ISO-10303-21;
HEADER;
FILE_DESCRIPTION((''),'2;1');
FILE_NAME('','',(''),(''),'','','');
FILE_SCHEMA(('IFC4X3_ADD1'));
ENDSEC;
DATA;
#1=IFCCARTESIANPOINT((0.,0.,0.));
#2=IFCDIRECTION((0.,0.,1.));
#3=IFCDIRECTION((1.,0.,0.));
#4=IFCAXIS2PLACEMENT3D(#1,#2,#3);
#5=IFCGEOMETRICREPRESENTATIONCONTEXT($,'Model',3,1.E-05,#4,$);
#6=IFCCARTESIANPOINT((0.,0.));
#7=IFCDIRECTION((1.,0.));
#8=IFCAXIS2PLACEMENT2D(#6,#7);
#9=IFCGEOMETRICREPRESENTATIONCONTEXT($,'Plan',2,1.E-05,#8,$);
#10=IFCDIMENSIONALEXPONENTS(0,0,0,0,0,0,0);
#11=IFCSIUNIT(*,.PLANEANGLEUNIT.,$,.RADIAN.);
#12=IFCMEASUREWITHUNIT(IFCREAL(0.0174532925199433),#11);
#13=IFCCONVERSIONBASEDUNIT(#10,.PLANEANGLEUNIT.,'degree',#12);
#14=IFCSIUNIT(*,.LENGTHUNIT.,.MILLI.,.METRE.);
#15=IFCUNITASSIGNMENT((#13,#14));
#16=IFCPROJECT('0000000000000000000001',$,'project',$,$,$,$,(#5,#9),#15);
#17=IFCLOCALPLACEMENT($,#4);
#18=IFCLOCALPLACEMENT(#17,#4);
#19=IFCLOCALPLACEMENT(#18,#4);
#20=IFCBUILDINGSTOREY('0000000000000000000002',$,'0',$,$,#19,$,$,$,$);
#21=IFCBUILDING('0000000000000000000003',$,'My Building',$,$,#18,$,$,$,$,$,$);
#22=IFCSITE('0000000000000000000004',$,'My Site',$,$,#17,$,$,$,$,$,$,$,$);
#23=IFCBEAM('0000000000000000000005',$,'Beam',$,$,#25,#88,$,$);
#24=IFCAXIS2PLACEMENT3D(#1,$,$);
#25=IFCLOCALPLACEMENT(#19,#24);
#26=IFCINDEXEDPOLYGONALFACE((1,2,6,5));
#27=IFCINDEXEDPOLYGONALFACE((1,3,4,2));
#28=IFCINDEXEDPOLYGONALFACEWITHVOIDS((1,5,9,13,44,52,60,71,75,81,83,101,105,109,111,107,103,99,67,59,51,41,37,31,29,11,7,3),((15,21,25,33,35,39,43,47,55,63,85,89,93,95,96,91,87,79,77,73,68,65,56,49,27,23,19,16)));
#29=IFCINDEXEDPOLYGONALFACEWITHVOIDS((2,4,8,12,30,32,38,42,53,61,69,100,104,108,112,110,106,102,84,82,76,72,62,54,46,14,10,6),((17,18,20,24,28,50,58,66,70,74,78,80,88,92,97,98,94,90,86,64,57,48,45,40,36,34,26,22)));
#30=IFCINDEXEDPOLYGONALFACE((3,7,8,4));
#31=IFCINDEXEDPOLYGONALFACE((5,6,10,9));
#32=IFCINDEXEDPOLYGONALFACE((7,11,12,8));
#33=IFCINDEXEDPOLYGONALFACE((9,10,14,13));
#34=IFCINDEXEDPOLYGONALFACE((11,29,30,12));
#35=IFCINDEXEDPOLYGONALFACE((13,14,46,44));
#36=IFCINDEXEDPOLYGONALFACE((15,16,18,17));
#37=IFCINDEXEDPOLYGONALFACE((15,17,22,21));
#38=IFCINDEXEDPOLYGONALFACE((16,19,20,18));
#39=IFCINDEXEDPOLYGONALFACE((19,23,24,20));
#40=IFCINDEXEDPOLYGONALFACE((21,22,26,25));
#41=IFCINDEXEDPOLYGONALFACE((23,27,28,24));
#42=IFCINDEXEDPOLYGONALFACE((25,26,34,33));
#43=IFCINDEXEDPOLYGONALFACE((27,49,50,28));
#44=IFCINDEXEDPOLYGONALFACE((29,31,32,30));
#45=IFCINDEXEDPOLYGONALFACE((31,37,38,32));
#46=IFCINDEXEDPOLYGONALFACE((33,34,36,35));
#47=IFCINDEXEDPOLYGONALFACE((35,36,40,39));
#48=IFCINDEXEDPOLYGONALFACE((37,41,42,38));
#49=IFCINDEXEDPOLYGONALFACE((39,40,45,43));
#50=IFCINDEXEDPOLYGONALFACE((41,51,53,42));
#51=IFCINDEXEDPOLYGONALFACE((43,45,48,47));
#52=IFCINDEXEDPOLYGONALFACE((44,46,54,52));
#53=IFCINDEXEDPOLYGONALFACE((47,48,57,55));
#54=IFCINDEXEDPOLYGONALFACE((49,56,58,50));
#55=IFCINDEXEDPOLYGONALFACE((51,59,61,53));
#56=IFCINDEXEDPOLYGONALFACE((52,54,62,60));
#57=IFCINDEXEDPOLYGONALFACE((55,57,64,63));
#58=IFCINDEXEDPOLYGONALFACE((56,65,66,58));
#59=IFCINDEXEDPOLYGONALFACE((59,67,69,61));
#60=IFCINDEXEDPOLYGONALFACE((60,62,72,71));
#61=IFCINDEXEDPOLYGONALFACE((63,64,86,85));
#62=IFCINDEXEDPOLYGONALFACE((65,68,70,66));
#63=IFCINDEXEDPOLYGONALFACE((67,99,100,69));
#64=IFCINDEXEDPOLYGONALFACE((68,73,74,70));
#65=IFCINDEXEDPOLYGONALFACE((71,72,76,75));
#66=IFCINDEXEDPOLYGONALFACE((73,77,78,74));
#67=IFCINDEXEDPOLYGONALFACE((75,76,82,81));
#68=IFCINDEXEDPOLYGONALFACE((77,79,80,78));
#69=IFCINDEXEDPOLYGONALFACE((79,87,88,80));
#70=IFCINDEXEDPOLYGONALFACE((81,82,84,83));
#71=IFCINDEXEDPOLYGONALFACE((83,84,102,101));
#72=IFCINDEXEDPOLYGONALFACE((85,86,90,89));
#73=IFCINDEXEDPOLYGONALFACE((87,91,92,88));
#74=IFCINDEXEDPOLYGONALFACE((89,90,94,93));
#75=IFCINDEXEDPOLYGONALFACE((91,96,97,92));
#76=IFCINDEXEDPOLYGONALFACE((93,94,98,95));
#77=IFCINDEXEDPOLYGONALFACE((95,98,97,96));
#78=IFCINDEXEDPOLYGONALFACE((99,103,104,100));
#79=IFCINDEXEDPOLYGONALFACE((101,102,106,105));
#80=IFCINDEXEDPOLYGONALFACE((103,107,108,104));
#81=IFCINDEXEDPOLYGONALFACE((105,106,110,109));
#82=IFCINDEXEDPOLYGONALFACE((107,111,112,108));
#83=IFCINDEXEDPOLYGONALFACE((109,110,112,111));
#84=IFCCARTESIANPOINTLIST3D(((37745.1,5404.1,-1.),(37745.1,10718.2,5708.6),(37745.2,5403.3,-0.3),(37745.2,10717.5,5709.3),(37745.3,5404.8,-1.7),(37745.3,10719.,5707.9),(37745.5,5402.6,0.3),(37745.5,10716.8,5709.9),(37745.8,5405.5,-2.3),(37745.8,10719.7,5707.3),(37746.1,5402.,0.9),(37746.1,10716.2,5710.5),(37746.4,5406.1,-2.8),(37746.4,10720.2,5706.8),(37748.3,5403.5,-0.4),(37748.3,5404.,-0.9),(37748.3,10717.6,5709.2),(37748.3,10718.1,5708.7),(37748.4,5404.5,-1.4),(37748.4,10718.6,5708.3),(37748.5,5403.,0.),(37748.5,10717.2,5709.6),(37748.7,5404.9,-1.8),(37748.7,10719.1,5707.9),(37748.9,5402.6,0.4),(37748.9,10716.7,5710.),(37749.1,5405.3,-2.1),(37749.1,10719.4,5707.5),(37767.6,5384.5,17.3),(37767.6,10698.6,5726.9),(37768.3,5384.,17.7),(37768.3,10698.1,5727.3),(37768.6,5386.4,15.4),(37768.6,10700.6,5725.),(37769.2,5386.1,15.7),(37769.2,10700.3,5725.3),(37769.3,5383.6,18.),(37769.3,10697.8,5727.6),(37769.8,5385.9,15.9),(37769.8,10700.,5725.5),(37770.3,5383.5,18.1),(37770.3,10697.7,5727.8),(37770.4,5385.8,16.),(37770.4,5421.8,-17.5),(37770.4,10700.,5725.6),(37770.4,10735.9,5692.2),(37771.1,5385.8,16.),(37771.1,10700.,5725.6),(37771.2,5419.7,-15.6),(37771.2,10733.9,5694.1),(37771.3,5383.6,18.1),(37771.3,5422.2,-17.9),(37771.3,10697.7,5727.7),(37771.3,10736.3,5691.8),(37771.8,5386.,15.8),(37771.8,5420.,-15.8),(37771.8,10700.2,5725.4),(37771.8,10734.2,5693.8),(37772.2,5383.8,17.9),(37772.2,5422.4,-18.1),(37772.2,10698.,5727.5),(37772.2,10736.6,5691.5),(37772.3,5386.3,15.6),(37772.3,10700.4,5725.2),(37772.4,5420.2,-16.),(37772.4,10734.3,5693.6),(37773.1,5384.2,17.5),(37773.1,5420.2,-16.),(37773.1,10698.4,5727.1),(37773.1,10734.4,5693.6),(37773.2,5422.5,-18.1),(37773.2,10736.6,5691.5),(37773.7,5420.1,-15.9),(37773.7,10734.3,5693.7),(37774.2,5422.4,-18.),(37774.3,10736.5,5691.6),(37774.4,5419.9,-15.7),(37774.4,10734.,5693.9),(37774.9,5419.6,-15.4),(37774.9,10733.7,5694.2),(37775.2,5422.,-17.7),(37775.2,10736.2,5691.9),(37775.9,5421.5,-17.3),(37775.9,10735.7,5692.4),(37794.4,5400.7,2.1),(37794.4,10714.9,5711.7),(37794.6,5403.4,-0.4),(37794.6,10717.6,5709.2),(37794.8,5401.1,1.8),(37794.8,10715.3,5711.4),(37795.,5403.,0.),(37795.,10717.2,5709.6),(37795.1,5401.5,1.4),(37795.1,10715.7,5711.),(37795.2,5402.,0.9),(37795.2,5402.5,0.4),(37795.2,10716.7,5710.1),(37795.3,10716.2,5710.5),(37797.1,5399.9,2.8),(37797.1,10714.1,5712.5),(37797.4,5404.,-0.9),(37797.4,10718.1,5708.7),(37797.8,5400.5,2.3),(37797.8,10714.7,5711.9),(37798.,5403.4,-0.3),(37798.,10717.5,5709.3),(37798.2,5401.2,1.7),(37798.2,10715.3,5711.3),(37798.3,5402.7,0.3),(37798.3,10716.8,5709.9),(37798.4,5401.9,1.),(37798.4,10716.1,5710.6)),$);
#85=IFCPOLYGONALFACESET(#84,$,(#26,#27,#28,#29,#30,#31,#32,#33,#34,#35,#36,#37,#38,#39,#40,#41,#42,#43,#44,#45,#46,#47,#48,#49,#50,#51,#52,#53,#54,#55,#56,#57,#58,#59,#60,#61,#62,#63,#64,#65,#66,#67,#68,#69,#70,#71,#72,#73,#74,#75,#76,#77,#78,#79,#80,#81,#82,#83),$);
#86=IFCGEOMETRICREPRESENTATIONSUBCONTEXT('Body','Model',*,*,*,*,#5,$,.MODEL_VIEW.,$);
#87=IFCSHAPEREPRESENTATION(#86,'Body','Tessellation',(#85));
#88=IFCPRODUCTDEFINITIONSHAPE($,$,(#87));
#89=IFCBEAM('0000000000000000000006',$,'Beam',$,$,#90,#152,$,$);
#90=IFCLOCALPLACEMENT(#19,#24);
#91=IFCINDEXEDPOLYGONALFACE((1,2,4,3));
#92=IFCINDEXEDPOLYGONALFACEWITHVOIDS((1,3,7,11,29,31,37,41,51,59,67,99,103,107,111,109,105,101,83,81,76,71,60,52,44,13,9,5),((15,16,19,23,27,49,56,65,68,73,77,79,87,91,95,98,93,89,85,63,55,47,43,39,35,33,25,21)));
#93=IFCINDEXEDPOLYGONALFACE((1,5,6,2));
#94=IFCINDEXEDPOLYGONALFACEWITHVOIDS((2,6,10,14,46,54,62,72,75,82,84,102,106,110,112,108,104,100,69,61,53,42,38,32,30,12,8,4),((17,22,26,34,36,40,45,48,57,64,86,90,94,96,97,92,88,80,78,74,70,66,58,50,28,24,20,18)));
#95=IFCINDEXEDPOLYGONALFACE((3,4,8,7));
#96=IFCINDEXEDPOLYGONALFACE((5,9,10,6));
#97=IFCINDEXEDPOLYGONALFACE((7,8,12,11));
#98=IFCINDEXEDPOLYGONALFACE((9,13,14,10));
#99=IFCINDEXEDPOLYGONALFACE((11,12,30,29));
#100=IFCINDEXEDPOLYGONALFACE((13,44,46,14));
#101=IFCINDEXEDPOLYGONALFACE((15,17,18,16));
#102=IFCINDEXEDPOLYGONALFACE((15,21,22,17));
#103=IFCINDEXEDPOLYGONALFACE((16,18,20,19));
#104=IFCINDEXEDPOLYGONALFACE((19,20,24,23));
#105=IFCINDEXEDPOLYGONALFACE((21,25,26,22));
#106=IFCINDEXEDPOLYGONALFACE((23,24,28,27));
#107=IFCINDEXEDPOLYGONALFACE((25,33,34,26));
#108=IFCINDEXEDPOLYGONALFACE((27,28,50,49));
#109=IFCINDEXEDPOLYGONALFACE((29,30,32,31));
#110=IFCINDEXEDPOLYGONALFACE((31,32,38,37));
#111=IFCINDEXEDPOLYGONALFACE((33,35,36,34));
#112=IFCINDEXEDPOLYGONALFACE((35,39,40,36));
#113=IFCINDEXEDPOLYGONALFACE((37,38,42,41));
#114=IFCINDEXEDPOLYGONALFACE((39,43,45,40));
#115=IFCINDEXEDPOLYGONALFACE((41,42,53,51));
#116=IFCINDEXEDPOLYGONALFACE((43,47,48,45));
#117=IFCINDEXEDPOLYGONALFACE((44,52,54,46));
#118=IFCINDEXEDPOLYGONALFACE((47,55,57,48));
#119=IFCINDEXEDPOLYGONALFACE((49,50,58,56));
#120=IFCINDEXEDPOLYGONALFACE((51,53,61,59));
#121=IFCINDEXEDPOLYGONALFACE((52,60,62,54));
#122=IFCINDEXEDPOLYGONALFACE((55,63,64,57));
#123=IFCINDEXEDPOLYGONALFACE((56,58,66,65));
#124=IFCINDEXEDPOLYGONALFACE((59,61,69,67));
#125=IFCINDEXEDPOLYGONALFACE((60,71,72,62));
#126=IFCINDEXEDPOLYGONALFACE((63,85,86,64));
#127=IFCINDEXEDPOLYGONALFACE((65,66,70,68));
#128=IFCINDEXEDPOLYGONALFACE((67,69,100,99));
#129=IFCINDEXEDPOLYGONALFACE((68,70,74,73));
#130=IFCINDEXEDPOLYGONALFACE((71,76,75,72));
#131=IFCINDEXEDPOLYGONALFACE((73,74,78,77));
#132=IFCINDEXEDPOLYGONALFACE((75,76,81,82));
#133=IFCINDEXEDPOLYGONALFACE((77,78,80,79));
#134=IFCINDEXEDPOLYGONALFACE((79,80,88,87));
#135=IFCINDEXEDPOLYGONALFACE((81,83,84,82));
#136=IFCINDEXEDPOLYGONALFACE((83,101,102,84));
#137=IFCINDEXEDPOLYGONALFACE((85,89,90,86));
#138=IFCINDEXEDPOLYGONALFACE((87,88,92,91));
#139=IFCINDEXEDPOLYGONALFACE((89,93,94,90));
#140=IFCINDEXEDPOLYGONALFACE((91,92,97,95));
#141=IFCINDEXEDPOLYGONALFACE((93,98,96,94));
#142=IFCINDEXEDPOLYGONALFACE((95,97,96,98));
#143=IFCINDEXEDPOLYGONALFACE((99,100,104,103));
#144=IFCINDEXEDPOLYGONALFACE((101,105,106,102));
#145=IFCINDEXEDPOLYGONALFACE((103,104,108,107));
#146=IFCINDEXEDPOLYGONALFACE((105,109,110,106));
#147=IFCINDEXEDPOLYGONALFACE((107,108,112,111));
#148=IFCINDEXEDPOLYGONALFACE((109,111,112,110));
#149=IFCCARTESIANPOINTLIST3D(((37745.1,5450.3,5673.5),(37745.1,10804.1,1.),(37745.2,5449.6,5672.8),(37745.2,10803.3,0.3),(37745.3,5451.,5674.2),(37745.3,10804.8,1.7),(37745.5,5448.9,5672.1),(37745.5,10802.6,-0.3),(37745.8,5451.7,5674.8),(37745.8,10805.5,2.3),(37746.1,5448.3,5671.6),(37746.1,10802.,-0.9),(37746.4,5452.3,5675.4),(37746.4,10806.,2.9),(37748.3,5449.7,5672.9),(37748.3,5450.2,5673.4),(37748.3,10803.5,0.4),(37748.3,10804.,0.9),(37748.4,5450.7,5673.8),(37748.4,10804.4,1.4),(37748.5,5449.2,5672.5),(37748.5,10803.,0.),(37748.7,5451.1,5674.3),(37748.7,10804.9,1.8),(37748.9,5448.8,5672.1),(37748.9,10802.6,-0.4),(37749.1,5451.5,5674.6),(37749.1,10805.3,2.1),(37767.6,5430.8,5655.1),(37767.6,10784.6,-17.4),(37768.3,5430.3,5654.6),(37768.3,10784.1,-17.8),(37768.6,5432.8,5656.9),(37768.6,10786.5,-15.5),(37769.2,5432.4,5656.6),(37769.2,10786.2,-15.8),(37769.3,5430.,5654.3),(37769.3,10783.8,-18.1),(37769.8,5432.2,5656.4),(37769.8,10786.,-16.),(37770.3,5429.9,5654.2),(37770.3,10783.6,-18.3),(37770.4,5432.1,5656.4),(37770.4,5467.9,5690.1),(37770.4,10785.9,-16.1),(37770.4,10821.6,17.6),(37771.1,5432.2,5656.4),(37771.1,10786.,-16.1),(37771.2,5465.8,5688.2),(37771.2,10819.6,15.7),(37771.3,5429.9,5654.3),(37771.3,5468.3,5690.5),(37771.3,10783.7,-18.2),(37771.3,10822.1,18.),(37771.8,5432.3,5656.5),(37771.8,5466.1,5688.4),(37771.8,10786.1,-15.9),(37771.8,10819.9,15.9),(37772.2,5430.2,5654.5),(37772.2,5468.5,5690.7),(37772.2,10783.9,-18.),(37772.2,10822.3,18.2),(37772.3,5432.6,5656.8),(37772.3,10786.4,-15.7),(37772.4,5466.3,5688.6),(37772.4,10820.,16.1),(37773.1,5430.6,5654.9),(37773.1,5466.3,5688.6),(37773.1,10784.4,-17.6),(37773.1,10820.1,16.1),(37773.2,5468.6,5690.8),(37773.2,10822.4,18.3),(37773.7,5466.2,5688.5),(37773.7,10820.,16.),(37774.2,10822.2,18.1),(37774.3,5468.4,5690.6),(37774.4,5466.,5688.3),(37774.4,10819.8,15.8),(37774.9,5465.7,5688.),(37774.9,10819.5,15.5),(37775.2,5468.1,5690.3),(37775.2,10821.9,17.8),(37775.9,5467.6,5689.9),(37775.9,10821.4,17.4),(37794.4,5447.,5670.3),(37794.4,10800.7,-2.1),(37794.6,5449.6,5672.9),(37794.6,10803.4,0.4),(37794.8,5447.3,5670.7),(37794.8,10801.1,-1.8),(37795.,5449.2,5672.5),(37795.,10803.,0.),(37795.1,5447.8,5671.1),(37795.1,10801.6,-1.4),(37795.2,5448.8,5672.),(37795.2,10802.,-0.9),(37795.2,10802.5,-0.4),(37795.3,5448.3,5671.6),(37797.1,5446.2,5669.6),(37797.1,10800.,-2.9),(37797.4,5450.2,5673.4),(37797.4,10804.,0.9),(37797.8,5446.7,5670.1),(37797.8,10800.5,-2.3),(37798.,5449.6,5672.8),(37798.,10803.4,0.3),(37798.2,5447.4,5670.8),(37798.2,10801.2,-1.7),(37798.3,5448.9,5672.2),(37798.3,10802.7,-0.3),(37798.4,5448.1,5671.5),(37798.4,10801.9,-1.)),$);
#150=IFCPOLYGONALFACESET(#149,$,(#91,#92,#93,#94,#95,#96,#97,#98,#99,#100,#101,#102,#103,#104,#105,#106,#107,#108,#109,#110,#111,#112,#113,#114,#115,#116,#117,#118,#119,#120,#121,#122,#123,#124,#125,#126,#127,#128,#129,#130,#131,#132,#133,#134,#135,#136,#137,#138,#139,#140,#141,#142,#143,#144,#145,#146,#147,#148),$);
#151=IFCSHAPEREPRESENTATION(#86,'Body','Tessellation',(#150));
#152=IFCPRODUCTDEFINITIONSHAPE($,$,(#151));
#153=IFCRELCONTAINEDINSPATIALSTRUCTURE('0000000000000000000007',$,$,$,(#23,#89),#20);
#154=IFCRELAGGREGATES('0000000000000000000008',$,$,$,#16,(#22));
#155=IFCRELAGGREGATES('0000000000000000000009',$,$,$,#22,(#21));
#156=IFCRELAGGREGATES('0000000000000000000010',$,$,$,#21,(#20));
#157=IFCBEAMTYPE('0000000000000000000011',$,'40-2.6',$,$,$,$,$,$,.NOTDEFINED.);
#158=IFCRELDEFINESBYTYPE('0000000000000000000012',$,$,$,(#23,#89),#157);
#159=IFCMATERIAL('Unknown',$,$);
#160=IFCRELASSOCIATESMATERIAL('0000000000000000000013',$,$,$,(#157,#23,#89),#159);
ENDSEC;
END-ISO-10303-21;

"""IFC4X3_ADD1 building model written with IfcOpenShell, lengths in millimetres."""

from ifc_helpers import new_model, entity, si_unit, converted_unit, frame, origin_with_axes, origin_2d_with_axis, place, context, subcontext, project, spatial, hollow_rectangle, extrude, material, material_profile, profile_set, profile_usage, type_object, element, save


model = new_model("IFC4X3_ADD1")

# Units and contexts
model_context = context("Model", 3, precision=1e-05, world=origin_with_axes())
plan_context = context("Plan", 2, precision=1e-05, world=origin_2d_with_axis())
body_context = subcontext(model_context, "Body", "Model", "MODEL_VIEW")
ifc_project = project(units=[converted_unit("PLANEANGLEUNIT", "degree", entity("IfcReal", 0.0174532925199433), si_unit("PLANEANGLEUNIT", "RADIAN"), dimensions=[0, 0, 0, 0, 0, 0, 0]), si_unit("LENGTHUNIT", "METRE", prefix="MILLI")], contexts=[model_context, plan_context])

# Site, building, storey
site_placement = place(None, origin_with_axes())
site = spatial("IfcSite", under=ifc_project, at=site_placement, Name="My Site")
building_placement = place(site_placement, origin_with_axes())
building = spatial("IfcBuilding", under=site, at=building_placement, Name="My Building")
storey_placement = place(building_placement, origin_with_axes())
storey = spatial("IfcBuildingStorey", under=building, at=storey_placement, Name="0")

# Shared definitions
ifc_material = material(Name="Unknown")

# Beams
ifc_material_profile_1 = material_profile(ifc_material, hollow_rectangle(XDim=40.0, YDim=40.0, WallThickness=2.6, InnerFilletRadius=2.6, OuterFilletRadius=3.9))
ifc_profile_set_1 = profile_set([ifc_material_profile_1])
ifc_profile_usage_1 = profile_usage(ifc_profile_set_1, cardinal=5)
beam_type = type_object("IfcBeamType", Name="40-2.6", PredefinedType="NOTDEFINED", material=ifc_profile_set_1)
beam_1_placement = place(storey_placement, frame((37771.8, 5403.0, 0.0), z_axis=(0.0, 0.681302, 0.732003), x_axis=(-0.666409, 0.545771, -0.507969)))
element("IfcBeam", 1, at=beam_1_placement, inside=storey, type_object=beam_type, material=ifc_profile_usage_1, Name="Beam", context=body_context, shape_type="SweptSolid", body=[
    extrude(hollow_rectangle(XDim=40.0, YDim=40.0, WallThickness=2.6, InnerFilletRadius=2.6, OuterFilletRadius=3.9), origin_with_axes(), (0.0, 0.0, 1.0), 7800.0),
])
ifc_profile_usage_2 = profile_usage(ifc_profile_set_1, cardinal=5)
beam_2_placement = place(storey_placement, frame((37771.8, 10803.0, 0.0), z_axis=(0.0, -0.686382, 0.727241), x_axis=(-0.666409, 0.542221, 0.511757)))
element("IfcBeam", 2, at=beam_2_placement, inside=storey, type_object=beam_type, material=ifc_profile_usage_2, Name="Beam", context=body_context, shape_type="SweptSolid", body=[
    extrude(hollow_rectangle(XDim=40.0, YDim=40.0, WallThickness=2.6, InnerFilletRadius=2.6, OuterFilletRadius=3.9), origin_with_axes(), (0.0, 0.0, 1.0), 7800.0),
])

save(model, "model.ifc")
